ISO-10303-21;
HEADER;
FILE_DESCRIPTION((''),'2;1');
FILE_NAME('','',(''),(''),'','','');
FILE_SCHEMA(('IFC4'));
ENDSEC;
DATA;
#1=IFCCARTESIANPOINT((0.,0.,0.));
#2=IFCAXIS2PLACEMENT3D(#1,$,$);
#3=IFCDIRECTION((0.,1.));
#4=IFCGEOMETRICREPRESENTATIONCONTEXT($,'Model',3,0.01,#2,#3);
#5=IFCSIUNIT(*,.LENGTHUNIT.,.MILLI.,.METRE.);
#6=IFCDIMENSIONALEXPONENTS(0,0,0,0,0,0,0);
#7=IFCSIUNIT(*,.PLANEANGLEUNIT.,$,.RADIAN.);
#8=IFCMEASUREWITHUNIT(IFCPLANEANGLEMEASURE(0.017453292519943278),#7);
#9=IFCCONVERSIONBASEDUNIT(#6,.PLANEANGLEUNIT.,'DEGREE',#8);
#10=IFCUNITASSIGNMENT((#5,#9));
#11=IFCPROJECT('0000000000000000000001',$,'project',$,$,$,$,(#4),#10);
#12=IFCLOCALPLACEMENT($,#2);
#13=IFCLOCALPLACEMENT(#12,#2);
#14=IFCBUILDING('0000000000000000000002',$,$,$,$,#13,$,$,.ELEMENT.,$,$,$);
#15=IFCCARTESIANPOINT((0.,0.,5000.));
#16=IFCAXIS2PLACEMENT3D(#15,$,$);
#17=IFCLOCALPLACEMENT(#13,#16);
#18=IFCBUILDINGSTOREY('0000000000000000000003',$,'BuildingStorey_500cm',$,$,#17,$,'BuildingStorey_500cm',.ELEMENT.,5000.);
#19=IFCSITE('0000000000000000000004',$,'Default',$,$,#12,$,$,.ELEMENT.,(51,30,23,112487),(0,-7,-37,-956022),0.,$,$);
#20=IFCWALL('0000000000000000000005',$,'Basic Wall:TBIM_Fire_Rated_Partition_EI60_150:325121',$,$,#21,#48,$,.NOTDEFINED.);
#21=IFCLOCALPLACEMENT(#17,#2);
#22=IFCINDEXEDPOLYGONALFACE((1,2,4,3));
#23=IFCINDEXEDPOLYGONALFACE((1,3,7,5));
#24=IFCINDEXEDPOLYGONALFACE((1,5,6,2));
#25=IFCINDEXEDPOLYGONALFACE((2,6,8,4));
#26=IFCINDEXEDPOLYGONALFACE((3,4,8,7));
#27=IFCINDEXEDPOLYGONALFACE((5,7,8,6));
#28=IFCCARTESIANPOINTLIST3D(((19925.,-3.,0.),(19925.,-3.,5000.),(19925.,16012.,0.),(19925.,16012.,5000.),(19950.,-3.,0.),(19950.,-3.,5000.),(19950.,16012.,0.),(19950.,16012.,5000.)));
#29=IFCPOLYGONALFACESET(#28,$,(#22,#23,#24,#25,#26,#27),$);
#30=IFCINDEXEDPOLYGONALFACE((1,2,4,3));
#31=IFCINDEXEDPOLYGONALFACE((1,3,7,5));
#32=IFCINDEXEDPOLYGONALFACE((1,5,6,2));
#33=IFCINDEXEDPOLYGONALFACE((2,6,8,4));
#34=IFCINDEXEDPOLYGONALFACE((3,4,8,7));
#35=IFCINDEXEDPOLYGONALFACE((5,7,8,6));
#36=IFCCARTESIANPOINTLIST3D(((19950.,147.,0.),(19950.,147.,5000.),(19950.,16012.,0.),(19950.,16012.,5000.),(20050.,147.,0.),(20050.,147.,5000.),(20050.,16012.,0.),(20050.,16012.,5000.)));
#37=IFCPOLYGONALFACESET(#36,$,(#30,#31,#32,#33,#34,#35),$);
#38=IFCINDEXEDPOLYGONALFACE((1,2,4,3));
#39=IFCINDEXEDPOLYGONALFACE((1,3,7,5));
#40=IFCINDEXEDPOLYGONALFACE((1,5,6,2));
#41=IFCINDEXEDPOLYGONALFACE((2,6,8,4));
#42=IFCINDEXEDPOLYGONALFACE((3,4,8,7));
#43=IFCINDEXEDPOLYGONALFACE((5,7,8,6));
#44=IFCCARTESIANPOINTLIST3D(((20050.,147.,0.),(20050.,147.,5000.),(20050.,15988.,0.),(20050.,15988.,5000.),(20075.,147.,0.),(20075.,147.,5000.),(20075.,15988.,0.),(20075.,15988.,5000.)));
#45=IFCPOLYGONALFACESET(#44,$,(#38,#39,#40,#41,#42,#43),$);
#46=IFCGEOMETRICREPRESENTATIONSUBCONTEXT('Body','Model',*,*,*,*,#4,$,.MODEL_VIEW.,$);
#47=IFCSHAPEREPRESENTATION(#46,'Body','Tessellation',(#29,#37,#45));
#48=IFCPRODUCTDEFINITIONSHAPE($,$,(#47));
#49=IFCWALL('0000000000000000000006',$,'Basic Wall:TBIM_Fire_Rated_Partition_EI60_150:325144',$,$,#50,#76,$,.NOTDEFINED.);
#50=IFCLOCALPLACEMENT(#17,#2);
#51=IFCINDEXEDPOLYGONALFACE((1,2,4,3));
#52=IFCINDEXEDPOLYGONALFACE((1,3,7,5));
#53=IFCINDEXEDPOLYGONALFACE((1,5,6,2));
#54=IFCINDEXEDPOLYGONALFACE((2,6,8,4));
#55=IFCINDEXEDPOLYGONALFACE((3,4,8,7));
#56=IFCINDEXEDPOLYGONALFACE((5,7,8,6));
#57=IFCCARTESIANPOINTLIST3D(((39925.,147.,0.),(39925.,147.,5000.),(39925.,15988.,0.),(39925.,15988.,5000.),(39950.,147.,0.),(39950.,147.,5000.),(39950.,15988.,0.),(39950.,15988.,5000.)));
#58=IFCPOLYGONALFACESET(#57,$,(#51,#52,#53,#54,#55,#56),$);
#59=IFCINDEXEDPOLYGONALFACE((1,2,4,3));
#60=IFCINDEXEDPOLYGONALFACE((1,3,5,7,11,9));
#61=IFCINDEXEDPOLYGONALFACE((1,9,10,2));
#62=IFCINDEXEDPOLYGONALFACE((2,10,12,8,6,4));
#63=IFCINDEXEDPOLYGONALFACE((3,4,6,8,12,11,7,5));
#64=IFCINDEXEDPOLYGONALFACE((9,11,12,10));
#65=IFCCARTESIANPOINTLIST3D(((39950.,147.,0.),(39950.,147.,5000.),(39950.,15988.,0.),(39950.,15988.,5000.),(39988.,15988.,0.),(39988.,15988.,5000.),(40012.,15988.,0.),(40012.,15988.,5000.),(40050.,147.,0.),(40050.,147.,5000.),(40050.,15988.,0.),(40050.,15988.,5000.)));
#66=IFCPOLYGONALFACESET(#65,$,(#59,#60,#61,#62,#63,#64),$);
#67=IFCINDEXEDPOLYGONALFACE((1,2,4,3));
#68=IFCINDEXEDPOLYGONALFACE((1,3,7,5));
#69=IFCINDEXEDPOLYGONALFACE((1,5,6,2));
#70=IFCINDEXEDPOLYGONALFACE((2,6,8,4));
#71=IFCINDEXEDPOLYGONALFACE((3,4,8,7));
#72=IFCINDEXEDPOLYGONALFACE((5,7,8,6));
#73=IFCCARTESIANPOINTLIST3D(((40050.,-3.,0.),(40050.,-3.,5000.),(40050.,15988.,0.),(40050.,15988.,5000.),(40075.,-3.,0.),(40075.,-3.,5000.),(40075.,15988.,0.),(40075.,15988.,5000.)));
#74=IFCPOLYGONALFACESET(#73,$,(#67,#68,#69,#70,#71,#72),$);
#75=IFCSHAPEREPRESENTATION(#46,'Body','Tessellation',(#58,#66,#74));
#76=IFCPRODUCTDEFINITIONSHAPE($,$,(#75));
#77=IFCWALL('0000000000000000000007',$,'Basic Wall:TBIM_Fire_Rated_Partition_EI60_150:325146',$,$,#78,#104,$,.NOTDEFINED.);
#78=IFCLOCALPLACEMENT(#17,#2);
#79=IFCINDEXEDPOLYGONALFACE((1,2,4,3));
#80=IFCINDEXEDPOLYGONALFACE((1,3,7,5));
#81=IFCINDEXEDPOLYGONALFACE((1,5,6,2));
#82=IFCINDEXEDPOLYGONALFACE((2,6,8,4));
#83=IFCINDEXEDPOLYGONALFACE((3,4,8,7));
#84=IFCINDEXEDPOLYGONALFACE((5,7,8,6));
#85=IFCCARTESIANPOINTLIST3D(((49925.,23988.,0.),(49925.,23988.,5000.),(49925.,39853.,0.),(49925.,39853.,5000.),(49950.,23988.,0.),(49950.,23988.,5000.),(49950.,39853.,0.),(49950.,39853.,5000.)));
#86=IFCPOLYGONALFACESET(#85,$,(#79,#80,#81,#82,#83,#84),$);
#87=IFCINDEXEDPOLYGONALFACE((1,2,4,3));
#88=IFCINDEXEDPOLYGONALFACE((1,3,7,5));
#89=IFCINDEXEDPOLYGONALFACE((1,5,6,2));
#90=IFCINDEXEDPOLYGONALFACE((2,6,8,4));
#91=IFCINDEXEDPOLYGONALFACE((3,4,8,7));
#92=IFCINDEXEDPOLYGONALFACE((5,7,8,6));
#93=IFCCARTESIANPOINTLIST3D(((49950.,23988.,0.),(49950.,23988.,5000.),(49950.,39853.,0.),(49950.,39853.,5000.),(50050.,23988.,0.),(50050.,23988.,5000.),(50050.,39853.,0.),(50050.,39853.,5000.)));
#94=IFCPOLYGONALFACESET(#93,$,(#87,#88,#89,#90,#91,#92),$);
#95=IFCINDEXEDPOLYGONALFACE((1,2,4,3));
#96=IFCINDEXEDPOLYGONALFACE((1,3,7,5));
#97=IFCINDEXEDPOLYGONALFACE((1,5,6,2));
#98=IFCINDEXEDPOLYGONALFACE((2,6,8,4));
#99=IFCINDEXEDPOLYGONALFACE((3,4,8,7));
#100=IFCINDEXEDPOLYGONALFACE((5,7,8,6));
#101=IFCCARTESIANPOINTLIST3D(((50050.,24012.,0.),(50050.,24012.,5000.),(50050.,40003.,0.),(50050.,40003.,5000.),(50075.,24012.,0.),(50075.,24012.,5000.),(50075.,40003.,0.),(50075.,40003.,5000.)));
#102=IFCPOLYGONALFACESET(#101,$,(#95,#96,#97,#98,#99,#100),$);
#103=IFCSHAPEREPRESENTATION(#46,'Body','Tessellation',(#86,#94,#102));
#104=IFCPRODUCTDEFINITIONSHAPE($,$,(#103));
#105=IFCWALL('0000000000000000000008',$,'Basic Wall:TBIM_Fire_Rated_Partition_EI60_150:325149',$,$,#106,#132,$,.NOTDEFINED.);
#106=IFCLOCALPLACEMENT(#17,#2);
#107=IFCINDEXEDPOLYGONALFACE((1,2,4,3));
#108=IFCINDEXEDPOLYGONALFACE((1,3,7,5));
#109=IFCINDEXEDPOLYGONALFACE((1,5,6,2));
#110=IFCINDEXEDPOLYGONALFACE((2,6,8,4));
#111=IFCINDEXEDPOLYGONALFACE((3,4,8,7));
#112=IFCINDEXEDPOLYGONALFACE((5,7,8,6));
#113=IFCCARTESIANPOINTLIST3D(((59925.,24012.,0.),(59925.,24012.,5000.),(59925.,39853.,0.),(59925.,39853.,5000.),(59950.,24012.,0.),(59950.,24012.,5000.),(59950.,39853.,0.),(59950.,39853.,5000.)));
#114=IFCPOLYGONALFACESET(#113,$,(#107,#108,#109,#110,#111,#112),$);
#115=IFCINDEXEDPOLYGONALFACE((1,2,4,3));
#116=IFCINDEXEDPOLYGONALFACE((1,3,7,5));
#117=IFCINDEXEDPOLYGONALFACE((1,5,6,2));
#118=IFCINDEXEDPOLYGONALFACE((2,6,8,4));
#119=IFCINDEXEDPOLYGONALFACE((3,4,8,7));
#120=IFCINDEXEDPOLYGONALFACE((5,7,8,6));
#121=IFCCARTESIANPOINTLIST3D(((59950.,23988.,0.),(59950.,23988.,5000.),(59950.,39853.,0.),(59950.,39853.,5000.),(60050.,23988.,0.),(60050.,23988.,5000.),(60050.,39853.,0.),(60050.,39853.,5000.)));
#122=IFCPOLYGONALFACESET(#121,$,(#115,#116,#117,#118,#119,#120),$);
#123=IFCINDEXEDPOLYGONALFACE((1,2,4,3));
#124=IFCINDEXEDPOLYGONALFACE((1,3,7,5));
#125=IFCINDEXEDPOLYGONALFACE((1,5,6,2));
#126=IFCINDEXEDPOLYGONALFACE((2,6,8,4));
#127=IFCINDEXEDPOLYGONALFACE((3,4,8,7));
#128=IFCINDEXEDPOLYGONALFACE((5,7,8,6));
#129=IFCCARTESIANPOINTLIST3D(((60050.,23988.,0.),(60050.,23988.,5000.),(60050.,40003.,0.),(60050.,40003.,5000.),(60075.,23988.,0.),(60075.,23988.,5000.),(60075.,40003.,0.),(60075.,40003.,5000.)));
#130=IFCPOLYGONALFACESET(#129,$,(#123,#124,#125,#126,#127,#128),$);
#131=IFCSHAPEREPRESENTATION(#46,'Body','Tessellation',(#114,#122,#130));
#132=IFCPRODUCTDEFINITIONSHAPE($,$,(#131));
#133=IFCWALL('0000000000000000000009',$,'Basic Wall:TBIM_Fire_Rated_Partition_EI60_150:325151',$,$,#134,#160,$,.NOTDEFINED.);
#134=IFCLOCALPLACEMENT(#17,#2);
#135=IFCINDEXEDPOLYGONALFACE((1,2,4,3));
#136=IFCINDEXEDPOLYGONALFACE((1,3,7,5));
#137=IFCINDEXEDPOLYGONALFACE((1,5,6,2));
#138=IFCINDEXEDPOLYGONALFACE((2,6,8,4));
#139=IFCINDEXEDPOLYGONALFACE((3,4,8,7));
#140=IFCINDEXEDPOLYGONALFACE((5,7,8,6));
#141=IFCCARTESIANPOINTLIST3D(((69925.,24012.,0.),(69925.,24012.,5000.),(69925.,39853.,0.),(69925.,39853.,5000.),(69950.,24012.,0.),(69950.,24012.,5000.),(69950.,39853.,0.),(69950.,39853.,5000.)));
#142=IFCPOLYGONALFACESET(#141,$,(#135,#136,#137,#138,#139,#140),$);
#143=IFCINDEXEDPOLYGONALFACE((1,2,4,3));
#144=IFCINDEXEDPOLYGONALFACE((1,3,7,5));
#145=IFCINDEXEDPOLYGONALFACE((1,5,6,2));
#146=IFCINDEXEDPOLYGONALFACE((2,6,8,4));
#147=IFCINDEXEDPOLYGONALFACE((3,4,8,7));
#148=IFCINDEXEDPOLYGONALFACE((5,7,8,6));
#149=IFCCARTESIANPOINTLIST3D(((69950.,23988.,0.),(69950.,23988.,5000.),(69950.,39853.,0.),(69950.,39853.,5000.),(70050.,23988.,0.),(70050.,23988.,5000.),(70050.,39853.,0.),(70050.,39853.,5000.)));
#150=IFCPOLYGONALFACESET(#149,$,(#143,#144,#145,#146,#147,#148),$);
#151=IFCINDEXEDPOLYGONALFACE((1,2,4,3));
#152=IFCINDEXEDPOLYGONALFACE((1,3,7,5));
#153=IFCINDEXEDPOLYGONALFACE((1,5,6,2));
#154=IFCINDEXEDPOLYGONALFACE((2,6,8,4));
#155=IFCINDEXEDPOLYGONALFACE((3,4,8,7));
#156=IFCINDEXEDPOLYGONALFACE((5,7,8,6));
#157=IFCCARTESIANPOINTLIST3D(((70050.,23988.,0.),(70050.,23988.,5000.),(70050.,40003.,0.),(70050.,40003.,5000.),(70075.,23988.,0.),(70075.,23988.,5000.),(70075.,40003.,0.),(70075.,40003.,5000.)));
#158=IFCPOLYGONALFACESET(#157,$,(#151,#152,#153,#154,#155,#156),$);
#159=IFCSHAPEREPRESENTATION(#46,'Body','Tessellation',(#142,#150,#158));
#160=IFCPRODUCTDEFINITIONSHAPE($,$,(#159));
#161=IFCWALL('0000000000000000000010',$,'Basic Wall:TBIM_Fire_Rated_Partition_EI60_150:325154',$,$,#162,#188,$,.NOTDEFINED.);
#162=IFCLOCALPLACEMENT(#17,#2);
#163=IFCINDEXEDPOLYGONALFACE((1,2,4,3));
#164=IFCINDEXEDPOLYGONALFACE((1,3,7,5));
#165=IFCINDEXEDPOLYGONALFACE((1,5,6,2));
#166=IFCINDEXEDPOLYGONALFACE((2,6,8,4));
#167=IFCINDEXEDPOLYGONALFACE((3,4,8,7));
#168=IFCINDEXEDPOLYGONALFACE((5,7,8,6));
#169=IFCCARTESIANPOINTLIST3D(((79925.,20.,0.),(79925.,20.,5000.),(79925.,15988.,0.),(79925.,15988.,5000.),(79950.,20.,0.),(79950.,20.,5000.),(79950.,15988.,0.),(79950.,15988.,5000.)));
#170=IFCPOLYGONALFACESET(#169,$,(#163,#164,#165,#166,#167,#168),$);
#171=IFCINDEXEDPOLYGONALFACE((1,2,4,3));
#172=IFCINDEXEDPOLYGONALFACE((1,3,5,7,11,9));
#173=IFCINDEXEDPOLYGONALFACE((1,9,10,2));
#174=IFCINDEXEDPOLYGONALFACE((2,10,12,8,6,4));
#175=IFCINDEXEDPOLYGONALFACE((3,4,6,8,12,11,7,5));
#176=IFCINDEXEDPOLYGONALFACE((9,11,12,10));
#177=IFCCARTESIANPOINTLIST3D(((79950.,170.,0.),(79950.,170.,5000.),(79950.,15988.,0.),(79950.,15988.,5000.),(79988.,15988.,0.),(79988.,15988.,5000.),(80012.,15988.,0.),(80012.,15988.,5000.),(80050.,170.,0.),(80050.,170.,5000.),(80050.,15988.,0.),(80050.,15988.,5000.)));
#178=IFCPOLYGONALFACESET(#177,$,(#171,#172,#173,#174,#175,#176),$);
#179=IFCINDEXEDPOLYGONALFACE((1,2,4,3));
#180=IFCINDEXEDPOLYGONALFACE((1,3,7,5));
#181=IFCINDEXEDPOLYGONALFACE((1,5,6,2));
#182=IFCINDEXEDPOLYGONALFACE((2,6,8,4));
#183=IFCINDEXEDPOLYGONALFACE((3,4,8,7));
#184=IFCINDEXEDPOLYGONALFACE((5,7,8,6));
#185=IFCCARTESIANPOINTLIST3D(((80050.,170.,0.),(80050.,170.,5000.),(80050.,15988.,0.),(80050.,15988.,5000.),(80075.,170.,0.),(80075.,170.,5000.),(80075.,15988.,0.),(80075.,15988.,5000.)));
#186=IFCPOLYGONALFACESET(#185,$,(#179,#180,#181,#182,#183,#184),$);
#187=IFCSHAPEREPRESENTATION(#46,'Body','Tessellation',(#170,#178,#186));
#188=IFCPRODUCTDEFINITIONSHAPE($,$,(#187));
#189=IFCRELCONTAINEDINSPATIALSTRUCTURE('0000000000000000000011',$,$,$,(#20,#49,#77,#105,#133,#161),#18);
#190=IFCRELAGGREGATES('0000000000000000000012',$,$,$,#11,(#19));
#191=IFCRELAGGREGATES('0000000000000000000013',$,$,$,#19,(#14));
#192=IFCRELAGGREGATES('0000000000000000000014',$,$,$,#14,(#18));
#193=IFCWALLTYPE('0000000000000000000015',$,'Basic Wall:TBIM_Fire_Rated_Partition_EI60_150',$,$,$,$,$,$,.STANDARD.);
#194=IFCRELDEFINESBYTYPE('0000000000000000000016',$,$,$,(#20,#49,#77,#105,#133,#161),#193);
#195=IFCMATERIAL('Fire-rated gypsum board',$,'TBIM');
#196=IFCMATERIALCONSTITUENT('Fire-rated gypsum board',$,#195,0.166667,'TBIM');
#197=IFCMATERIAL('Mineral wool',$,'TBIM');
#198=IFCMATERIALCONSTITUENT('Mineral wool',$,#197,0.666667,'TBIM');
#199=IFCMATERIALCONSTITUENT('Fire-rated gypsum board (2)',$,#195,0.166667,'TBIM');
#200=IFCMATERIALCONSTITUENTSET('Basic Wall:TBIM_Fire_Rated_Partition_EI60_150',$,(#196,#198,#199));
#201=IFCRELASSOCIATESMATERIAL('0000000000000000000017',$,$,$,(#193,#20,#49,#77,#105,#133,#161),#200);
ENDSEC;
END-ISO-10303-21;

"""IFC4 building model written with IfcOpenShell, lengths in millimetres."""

from ifc_helpers import new_model, entity, si_unit, converted_unit, direction, frame, origin, place, context, subcontext, project, spatial, indexed_curve, outline, extrude, material, constituent, constituent_set, type_object, element, save


model = new_model("IFC4")

# Units and contexts
model_context = context("Model", 3, precision=0.01, world=origin(), true_north=direction((0.0, 1.0)))
body_context = subcontext(model_context, "Body", "Model", "MODEL_VIEW")
ifc_project = project(units=[si_unit("LENGTHUNIT", "METRE", prefix="MILLI"), converted_unit("PLANEANGLEUNIT", "DEGREE", entity("IfcPlaneAngleMeasure", 0.017453292519943278), si_unit("PLANEANGLEUNIT", "RADIAN"), dimensions=[0, 0, 0, 0, 0, 0, 0])], contexts=[model_context])

# Site, building, storey
site_placement = place(None, origin())
site = spatial("IfcSite", under=ifc_project, at=site_placement, Name="Default", CompositionType="ELEMENT", RefLatitude=(51, 30, 23, 112487), RefLongitude=(0, -7, -37, -956022), RefElevation=0.0)
building_placement = place(site_placement, origin())
building = spatial("IfcBuilding", under=site, at=building_placement, CompositionType="ELEMENT")
storey_placement = place(building_placement, frame((0.0, 0.0, 5000.0)))
storey = spatial("IfcBuildingStorey", under=building, at=storey_placement, Name="BuildingStorey_500cm", LongName="BuildingStorey_500cm", CompositionType="ELEMENT", Elevation=5000.0)

# Shared definitions
ifc_material_1 = material(Name="Mineral wool", Category="TBIM")

# Walls
ifc_material_2 = material(Name="Fire-rated gypsum board", Category="TBIM")
ifc_constituent_1 = constituent(ifc_material_2, Name="Fire-rated gypsum board", Category="TBIM", fraction=0.166667)
ifc_constituent_2 = constituent(ifc_material_1, Name="Mineral wool", Category="TBIM", fraction=0.666667)
ifc_constituent_3 = constituent(ifc_material_2, Name="Fire-rated gypsum board (2)", Category="TBIM", fraction=0.166667)
ifc_constituent_set_1 = constituent_set(constituents=[ifc_constituent_1, ifc_constituent_2, ifc_constituent_3], Name="Basic Wall:TBIM_Fire_Rated_Partition_EI60_150")
wall_type_1 = type_object("IfcWallType", Name="Basic Wall:TBIM_Fire_Rated_Partition_EI60_150", PredefinedType="STANDARD", material=ifc_constituent_set_1)
wall_1_placement = place(storey_placement, frame((20000.0, 147.0, 0.0), z_axis=(0.0, 0.0, 1.0), x_axis=(0.0, 1.0, 0.0)))
element("IfcWall", 1, at=wall_1_placement, inside=storey, type_object=wall_type_1, material=ifc_constituent_set_1, Name="Basic Wall:TBIM_Fire_Rated_Partition_EI60_150:325121", PredefinedType="NOTDEFINED", context=body_context, shape_type="SweptSolid", body=[
    extrude(outline(indexed_curve([(-12.5, -8007.5), (12.5, -8007.5), (12.5, 8007.5), (-12.5, 8007.5), (-12.5, -8007.5)], self_intersect=False)), frame((7857.5, 62.5, 0.0), z_axis=(0.0, 0.0, 1.0), x_axis=(0.0, -1.0, 0.0)), (0.0, 0.0, 1.0), 5000.0),
    extrude(outline(indexed_curve([(-7932.5, -50.0), (7932.5, -50.0), (7932.5, 50.0), (-7932.5, 50.0), (-7932.5, -50.0)], self_intersect=False)), frame((7932.5, 0.0, 0.0)), (0.0, 0.0, 1.0), 5000.0),
    extrude(outline(indexed_curve([(-12.5, -7920.5), (12.5, -7920.5), (12.5, 7920.5), (-12.5, 7920.5), (-12.5, -7920.5)], self_intersect=False)), frame((7920.5, -62.5, 0.0), z_axis=(0.0, 0.0, 1.0), x_axis=(0.0, 1.0, 0.0)), (0.0, 0.0, 1.0), 5000.0),
])
wall_2_placement = place(storey_placement, frame((40000.0, 147.0, 0.0), z_axis=(0.0, 0.0, 1.0), x_axis=(0.0, 1.0, 0.0)))
element("IfcWall", 2, at=wall_2_placement, inside=storey, type_object=wall_type_1, material=ifc_constituent_set_1, Name="Basic Wall:TBIM_Fire_Rated_Partition_EI60_150:325144", PredefinedType="NOTDEFINED", context=body_context, shape_type="SweptSolid", body=[
    extrude(outline(indexed_curve([(-12.5, -7920.5), (12.5, -7920.5), (12.5, 7920.5), (-12.5, 7920.5), (-12.5, -7920.5)], self_intersect=False)), frame((7920.5, 62.5, 0.0), z_axis=(0.0, 0.0, 1.0), x_axis=(0.0, -1.0, 0.0)), (0.0, 0.0, 1.0), 5000.0),
    extrude(outline(indexed_curve([(12.0, -5280.3), (50.0, -5280.3), (50.0, 10560.7), (-50.0, 10560.7), (-50.0, -5280.3), (-12.0, -5280.3), (12.0, -5280.3)], self_intersect=False)), frame((10560.7, 0.0, 0.0), z_axis=(0.0, 0.0, 1.0), x_axis=(0.0, 1.0, 0.0)), (0.0, 0.0, 1.0), 5000.0),
    extrude(outline(indexed_curve([(-12.5, -7995.5), (12.5, -7995.5), (12.5, 7995.5), (-12.5, 7995.5), (-12.5, -7995.5)], self_intersect=False)), frame((7845.5, -62.5, 0.0), z_axis=(0.0, 0.0, 1.0), x_axis=(0.0, 1.0, 0.0)), (0.0, 0.0, 1.0), 5000.0),
])
wall_3_placement = place(storey_placement, frame((50000.0, 24012.0, 0.0), z_axis=(0.0, 0.0, 1.0), x_axis=(0.0, 1.0, 0.0)))
element("IfcWall", 3, at=wall_3_placement, inside=storey, type_object=wall_type_1, material=ifc_constituent_set_1, Name="Basic Wall:TBIM_Fire_Rated_Partition_EI60_150:325146", PredefinedType="NOTDEFINED", context=body_context, shape_type="SweptSolid", body=[
    extrude(outline(indexed_curve([(-12.5, -7932.5), (12.5, -7932.5), (12.5, 7932.5), (-12.5, 7932.5), (-12.5, -7932.5)], self_intersect=False)), frame((7908.5, 62.5, 0.0), z_axis=(0.0, 0.0, 1.0), x_axis=(0.0, -1.0, 0.0)), (0.0, 0.0, 1.0), 5000.0),
    extrude(outline(indexed_curve([(-7932.5, -50.0), (7932.5, -50.0), (7932.5, 50.0), (-7932.5, 50.0), (-7932.5, -50.0)], self_intersect=False)), frame((7908.5, 0.0, 0.0)), (0.0, 0.0, 1.0), 5000.0),
    extrude(outline(indexed_curve([(-12.5, -7995.5), (12.5, -7995.5), (12.5, 7995.5), (-12.5, 7995.5), (-12.5, -7995.5)], self_intersect=False)), frame((7995.5, -62.5, 0.0), z_axis=(0.0, 0.0, 1.0), x_axis=(0.0, 1.0, 0.0)), (0.0, 0.0, 1.0), 5000.0),
])
wall_4_placement = place(storey_placement, frame((60000.0, 24012.0, 0.0), z_axis=(0.0, 0.0, 1.0), x_axis=(0.0, 1.0, 0.0)))
element("IfcWall", 4, at=wall_4_placement, inside=storey, type_object=wall_type_1, material=ifc_constituent_set_1, Name="Basic Wall:TBIM_Fire_Rated_Partition_EI60_150:325149", PredefinedType="NOTDEFINED", context=body_context, shape_type="SweptSolid", body=[
    extrude(outline(indexed_curve([(-12.5, -7920.5), (12.5, -7920.5), (12.5, 7920.5), (-12.5, 7920.5), (-12.5, -7920.5)], self_intersect=False)), frame((7920.5, 62.5, 0.0), z_axis=(0.0, 0.0, 1.0), x_axis=(0.0, -1.0, 0.0)), (0.0, 0.0, 1.0), 5000.0),
    extrude(outline(indexed_curve([(-7932.5, -50.0), (7932.5, -50.0), (7932.5, 50.0), (-7932.5, 50.0), (-7932.5, -50.0)], self_intersect=False)), frame((7908.5, 0.0, 0.0)), (0.0, 0.0, 1.0), 5000.0),
    extrude(outline(indexed_curve([(-12.5, -8007.5), (12.5, -8007.5), (12.5, 8007.5), (-12.5, 8007.5), (-12.5, -8007.5)], self_intersect=False)), frame((7983.5, -62.5, 0.0), z_axis=(0.0, 0.0, 1.0), x_axis=(0.0, 1.0, 0.0)), (0.0, 0.0, 1.0), 5000.0),
])
wall_5_placement = place(storey_placement, frame((70000.0, 24012.0, 0.0), z_axis=(0.0, 0.0, 1.0), x_axis=(0.0, 1.0, 0.0)))
element("IfcWall", 5, at=wall_5_placement, inside=storey, type_object=wall_type_1, material=ifc_constituent_set_1, Name="Basic Wall:TBIM_Fire_Rated_Partition_EI60_150:325151", PredefinedType="NOTDEFINED", context=body_context, shape_type="SweptSolid", body=[
    extrude(outline(indexed_curve([(-12.5, -7920.5), (12.5, -7920.5), (12.5, 7920.5), (-12.5, 7920.5), (-12.5, -7920.5)], self_intersect=False)), frame((7920.5, 62.5, 0.0), z_axis=(0.0, 0.0, 1.0), x_axis=(0.0, -1.0, 0.0)), (0.0, 0.0, 1.0), 5000.0),
    extrude(outline(indexed_curve([(-7932.5, -50.0), (7932.5, -50.0), (7932.5, 50.0), (-7932.5, 50.0), (-7932.5, -50.0)], self_intersect=False)), frame((7908.5, 0.0, 0.0)), (0.0, 0.0, 1.0), 5000.0),
    extrude(outline(indexed_curve([(-12.5, -8007.5), (12.5, -8007.5), (12.5, 8007.5), (-12.5, 8007.5), (-12.5, -8007.5)], self_intersect=False)), frame((7983.5, -62.5, 0.0), z_axis=(0.0, 0.0, 1.0), x_axis=(0.0, 1.0, 0.0)), (0.0, 0.0, 1.0), 5000.0),
])
wall_6_placement = place(storey_placement, frame((80000.0, 170.0, 0.0), z_axis=(0.0, 0.0, 1.0), x_axis=(0.0, 1.0, 0.0)))
element("IfcWall", 6, at=wall_6_placement, inside=storey, type_object=wall_type_1, material=ifc_constituent_set_1, Name="Basic Wall:TBIM_Fire_Rated_Partition_EI60_150:325154", PredefinedType="NOTDEFINED", context=body_context, shape_type="SweptSolid", body=[
    extrude(outline(indexed_curve([(-12.5, -7984.0), (12.5, -7984.0), (12.5, 7984.0), (-12.5, 7984.0), (-12.5, -7984.0)], self_intersect=False)), frame((7834.0, 62.5, 0.0), z_axis=(0.0, 0.0, 1.0), x_axis=(0.0, -1.0, 0.0)), (0.0, 0.0, 1.0), 5000.0),
    extrude(outline(indexed_curve([(12.0, -5272.7), (50.0, -5272.7), (50.0, 10545.3), (-50.0, 10545.3), (-50.0, -5272.7), (-12.0, -5272.7), (12.0, -5272.7)], self_intersect=False)), frame((10545.3, 0.0, 0.0), z_axis=(0.0, 0.0, 1.0), x_axis=(0.0, 1.0, 0.0)), (0.0, 0.0, 1.0), 5000.0),
    extrude(outline(indexed_curve([(-12.5, -7909.0), (12.5, -7909.0), (12.5, 7909.0), (-12.5, 7909.0), (-12.5, -7909.0)], self_intersect=False)), frame((7909.0, -62.5, 0.0), z_axis=(0.0, 0.0, 1.0), x_axis=(0.0, 1.0, 0.0)), (0.0, 0.0, 1.0), 5000.0),
])

save(model, "model.ifc")
